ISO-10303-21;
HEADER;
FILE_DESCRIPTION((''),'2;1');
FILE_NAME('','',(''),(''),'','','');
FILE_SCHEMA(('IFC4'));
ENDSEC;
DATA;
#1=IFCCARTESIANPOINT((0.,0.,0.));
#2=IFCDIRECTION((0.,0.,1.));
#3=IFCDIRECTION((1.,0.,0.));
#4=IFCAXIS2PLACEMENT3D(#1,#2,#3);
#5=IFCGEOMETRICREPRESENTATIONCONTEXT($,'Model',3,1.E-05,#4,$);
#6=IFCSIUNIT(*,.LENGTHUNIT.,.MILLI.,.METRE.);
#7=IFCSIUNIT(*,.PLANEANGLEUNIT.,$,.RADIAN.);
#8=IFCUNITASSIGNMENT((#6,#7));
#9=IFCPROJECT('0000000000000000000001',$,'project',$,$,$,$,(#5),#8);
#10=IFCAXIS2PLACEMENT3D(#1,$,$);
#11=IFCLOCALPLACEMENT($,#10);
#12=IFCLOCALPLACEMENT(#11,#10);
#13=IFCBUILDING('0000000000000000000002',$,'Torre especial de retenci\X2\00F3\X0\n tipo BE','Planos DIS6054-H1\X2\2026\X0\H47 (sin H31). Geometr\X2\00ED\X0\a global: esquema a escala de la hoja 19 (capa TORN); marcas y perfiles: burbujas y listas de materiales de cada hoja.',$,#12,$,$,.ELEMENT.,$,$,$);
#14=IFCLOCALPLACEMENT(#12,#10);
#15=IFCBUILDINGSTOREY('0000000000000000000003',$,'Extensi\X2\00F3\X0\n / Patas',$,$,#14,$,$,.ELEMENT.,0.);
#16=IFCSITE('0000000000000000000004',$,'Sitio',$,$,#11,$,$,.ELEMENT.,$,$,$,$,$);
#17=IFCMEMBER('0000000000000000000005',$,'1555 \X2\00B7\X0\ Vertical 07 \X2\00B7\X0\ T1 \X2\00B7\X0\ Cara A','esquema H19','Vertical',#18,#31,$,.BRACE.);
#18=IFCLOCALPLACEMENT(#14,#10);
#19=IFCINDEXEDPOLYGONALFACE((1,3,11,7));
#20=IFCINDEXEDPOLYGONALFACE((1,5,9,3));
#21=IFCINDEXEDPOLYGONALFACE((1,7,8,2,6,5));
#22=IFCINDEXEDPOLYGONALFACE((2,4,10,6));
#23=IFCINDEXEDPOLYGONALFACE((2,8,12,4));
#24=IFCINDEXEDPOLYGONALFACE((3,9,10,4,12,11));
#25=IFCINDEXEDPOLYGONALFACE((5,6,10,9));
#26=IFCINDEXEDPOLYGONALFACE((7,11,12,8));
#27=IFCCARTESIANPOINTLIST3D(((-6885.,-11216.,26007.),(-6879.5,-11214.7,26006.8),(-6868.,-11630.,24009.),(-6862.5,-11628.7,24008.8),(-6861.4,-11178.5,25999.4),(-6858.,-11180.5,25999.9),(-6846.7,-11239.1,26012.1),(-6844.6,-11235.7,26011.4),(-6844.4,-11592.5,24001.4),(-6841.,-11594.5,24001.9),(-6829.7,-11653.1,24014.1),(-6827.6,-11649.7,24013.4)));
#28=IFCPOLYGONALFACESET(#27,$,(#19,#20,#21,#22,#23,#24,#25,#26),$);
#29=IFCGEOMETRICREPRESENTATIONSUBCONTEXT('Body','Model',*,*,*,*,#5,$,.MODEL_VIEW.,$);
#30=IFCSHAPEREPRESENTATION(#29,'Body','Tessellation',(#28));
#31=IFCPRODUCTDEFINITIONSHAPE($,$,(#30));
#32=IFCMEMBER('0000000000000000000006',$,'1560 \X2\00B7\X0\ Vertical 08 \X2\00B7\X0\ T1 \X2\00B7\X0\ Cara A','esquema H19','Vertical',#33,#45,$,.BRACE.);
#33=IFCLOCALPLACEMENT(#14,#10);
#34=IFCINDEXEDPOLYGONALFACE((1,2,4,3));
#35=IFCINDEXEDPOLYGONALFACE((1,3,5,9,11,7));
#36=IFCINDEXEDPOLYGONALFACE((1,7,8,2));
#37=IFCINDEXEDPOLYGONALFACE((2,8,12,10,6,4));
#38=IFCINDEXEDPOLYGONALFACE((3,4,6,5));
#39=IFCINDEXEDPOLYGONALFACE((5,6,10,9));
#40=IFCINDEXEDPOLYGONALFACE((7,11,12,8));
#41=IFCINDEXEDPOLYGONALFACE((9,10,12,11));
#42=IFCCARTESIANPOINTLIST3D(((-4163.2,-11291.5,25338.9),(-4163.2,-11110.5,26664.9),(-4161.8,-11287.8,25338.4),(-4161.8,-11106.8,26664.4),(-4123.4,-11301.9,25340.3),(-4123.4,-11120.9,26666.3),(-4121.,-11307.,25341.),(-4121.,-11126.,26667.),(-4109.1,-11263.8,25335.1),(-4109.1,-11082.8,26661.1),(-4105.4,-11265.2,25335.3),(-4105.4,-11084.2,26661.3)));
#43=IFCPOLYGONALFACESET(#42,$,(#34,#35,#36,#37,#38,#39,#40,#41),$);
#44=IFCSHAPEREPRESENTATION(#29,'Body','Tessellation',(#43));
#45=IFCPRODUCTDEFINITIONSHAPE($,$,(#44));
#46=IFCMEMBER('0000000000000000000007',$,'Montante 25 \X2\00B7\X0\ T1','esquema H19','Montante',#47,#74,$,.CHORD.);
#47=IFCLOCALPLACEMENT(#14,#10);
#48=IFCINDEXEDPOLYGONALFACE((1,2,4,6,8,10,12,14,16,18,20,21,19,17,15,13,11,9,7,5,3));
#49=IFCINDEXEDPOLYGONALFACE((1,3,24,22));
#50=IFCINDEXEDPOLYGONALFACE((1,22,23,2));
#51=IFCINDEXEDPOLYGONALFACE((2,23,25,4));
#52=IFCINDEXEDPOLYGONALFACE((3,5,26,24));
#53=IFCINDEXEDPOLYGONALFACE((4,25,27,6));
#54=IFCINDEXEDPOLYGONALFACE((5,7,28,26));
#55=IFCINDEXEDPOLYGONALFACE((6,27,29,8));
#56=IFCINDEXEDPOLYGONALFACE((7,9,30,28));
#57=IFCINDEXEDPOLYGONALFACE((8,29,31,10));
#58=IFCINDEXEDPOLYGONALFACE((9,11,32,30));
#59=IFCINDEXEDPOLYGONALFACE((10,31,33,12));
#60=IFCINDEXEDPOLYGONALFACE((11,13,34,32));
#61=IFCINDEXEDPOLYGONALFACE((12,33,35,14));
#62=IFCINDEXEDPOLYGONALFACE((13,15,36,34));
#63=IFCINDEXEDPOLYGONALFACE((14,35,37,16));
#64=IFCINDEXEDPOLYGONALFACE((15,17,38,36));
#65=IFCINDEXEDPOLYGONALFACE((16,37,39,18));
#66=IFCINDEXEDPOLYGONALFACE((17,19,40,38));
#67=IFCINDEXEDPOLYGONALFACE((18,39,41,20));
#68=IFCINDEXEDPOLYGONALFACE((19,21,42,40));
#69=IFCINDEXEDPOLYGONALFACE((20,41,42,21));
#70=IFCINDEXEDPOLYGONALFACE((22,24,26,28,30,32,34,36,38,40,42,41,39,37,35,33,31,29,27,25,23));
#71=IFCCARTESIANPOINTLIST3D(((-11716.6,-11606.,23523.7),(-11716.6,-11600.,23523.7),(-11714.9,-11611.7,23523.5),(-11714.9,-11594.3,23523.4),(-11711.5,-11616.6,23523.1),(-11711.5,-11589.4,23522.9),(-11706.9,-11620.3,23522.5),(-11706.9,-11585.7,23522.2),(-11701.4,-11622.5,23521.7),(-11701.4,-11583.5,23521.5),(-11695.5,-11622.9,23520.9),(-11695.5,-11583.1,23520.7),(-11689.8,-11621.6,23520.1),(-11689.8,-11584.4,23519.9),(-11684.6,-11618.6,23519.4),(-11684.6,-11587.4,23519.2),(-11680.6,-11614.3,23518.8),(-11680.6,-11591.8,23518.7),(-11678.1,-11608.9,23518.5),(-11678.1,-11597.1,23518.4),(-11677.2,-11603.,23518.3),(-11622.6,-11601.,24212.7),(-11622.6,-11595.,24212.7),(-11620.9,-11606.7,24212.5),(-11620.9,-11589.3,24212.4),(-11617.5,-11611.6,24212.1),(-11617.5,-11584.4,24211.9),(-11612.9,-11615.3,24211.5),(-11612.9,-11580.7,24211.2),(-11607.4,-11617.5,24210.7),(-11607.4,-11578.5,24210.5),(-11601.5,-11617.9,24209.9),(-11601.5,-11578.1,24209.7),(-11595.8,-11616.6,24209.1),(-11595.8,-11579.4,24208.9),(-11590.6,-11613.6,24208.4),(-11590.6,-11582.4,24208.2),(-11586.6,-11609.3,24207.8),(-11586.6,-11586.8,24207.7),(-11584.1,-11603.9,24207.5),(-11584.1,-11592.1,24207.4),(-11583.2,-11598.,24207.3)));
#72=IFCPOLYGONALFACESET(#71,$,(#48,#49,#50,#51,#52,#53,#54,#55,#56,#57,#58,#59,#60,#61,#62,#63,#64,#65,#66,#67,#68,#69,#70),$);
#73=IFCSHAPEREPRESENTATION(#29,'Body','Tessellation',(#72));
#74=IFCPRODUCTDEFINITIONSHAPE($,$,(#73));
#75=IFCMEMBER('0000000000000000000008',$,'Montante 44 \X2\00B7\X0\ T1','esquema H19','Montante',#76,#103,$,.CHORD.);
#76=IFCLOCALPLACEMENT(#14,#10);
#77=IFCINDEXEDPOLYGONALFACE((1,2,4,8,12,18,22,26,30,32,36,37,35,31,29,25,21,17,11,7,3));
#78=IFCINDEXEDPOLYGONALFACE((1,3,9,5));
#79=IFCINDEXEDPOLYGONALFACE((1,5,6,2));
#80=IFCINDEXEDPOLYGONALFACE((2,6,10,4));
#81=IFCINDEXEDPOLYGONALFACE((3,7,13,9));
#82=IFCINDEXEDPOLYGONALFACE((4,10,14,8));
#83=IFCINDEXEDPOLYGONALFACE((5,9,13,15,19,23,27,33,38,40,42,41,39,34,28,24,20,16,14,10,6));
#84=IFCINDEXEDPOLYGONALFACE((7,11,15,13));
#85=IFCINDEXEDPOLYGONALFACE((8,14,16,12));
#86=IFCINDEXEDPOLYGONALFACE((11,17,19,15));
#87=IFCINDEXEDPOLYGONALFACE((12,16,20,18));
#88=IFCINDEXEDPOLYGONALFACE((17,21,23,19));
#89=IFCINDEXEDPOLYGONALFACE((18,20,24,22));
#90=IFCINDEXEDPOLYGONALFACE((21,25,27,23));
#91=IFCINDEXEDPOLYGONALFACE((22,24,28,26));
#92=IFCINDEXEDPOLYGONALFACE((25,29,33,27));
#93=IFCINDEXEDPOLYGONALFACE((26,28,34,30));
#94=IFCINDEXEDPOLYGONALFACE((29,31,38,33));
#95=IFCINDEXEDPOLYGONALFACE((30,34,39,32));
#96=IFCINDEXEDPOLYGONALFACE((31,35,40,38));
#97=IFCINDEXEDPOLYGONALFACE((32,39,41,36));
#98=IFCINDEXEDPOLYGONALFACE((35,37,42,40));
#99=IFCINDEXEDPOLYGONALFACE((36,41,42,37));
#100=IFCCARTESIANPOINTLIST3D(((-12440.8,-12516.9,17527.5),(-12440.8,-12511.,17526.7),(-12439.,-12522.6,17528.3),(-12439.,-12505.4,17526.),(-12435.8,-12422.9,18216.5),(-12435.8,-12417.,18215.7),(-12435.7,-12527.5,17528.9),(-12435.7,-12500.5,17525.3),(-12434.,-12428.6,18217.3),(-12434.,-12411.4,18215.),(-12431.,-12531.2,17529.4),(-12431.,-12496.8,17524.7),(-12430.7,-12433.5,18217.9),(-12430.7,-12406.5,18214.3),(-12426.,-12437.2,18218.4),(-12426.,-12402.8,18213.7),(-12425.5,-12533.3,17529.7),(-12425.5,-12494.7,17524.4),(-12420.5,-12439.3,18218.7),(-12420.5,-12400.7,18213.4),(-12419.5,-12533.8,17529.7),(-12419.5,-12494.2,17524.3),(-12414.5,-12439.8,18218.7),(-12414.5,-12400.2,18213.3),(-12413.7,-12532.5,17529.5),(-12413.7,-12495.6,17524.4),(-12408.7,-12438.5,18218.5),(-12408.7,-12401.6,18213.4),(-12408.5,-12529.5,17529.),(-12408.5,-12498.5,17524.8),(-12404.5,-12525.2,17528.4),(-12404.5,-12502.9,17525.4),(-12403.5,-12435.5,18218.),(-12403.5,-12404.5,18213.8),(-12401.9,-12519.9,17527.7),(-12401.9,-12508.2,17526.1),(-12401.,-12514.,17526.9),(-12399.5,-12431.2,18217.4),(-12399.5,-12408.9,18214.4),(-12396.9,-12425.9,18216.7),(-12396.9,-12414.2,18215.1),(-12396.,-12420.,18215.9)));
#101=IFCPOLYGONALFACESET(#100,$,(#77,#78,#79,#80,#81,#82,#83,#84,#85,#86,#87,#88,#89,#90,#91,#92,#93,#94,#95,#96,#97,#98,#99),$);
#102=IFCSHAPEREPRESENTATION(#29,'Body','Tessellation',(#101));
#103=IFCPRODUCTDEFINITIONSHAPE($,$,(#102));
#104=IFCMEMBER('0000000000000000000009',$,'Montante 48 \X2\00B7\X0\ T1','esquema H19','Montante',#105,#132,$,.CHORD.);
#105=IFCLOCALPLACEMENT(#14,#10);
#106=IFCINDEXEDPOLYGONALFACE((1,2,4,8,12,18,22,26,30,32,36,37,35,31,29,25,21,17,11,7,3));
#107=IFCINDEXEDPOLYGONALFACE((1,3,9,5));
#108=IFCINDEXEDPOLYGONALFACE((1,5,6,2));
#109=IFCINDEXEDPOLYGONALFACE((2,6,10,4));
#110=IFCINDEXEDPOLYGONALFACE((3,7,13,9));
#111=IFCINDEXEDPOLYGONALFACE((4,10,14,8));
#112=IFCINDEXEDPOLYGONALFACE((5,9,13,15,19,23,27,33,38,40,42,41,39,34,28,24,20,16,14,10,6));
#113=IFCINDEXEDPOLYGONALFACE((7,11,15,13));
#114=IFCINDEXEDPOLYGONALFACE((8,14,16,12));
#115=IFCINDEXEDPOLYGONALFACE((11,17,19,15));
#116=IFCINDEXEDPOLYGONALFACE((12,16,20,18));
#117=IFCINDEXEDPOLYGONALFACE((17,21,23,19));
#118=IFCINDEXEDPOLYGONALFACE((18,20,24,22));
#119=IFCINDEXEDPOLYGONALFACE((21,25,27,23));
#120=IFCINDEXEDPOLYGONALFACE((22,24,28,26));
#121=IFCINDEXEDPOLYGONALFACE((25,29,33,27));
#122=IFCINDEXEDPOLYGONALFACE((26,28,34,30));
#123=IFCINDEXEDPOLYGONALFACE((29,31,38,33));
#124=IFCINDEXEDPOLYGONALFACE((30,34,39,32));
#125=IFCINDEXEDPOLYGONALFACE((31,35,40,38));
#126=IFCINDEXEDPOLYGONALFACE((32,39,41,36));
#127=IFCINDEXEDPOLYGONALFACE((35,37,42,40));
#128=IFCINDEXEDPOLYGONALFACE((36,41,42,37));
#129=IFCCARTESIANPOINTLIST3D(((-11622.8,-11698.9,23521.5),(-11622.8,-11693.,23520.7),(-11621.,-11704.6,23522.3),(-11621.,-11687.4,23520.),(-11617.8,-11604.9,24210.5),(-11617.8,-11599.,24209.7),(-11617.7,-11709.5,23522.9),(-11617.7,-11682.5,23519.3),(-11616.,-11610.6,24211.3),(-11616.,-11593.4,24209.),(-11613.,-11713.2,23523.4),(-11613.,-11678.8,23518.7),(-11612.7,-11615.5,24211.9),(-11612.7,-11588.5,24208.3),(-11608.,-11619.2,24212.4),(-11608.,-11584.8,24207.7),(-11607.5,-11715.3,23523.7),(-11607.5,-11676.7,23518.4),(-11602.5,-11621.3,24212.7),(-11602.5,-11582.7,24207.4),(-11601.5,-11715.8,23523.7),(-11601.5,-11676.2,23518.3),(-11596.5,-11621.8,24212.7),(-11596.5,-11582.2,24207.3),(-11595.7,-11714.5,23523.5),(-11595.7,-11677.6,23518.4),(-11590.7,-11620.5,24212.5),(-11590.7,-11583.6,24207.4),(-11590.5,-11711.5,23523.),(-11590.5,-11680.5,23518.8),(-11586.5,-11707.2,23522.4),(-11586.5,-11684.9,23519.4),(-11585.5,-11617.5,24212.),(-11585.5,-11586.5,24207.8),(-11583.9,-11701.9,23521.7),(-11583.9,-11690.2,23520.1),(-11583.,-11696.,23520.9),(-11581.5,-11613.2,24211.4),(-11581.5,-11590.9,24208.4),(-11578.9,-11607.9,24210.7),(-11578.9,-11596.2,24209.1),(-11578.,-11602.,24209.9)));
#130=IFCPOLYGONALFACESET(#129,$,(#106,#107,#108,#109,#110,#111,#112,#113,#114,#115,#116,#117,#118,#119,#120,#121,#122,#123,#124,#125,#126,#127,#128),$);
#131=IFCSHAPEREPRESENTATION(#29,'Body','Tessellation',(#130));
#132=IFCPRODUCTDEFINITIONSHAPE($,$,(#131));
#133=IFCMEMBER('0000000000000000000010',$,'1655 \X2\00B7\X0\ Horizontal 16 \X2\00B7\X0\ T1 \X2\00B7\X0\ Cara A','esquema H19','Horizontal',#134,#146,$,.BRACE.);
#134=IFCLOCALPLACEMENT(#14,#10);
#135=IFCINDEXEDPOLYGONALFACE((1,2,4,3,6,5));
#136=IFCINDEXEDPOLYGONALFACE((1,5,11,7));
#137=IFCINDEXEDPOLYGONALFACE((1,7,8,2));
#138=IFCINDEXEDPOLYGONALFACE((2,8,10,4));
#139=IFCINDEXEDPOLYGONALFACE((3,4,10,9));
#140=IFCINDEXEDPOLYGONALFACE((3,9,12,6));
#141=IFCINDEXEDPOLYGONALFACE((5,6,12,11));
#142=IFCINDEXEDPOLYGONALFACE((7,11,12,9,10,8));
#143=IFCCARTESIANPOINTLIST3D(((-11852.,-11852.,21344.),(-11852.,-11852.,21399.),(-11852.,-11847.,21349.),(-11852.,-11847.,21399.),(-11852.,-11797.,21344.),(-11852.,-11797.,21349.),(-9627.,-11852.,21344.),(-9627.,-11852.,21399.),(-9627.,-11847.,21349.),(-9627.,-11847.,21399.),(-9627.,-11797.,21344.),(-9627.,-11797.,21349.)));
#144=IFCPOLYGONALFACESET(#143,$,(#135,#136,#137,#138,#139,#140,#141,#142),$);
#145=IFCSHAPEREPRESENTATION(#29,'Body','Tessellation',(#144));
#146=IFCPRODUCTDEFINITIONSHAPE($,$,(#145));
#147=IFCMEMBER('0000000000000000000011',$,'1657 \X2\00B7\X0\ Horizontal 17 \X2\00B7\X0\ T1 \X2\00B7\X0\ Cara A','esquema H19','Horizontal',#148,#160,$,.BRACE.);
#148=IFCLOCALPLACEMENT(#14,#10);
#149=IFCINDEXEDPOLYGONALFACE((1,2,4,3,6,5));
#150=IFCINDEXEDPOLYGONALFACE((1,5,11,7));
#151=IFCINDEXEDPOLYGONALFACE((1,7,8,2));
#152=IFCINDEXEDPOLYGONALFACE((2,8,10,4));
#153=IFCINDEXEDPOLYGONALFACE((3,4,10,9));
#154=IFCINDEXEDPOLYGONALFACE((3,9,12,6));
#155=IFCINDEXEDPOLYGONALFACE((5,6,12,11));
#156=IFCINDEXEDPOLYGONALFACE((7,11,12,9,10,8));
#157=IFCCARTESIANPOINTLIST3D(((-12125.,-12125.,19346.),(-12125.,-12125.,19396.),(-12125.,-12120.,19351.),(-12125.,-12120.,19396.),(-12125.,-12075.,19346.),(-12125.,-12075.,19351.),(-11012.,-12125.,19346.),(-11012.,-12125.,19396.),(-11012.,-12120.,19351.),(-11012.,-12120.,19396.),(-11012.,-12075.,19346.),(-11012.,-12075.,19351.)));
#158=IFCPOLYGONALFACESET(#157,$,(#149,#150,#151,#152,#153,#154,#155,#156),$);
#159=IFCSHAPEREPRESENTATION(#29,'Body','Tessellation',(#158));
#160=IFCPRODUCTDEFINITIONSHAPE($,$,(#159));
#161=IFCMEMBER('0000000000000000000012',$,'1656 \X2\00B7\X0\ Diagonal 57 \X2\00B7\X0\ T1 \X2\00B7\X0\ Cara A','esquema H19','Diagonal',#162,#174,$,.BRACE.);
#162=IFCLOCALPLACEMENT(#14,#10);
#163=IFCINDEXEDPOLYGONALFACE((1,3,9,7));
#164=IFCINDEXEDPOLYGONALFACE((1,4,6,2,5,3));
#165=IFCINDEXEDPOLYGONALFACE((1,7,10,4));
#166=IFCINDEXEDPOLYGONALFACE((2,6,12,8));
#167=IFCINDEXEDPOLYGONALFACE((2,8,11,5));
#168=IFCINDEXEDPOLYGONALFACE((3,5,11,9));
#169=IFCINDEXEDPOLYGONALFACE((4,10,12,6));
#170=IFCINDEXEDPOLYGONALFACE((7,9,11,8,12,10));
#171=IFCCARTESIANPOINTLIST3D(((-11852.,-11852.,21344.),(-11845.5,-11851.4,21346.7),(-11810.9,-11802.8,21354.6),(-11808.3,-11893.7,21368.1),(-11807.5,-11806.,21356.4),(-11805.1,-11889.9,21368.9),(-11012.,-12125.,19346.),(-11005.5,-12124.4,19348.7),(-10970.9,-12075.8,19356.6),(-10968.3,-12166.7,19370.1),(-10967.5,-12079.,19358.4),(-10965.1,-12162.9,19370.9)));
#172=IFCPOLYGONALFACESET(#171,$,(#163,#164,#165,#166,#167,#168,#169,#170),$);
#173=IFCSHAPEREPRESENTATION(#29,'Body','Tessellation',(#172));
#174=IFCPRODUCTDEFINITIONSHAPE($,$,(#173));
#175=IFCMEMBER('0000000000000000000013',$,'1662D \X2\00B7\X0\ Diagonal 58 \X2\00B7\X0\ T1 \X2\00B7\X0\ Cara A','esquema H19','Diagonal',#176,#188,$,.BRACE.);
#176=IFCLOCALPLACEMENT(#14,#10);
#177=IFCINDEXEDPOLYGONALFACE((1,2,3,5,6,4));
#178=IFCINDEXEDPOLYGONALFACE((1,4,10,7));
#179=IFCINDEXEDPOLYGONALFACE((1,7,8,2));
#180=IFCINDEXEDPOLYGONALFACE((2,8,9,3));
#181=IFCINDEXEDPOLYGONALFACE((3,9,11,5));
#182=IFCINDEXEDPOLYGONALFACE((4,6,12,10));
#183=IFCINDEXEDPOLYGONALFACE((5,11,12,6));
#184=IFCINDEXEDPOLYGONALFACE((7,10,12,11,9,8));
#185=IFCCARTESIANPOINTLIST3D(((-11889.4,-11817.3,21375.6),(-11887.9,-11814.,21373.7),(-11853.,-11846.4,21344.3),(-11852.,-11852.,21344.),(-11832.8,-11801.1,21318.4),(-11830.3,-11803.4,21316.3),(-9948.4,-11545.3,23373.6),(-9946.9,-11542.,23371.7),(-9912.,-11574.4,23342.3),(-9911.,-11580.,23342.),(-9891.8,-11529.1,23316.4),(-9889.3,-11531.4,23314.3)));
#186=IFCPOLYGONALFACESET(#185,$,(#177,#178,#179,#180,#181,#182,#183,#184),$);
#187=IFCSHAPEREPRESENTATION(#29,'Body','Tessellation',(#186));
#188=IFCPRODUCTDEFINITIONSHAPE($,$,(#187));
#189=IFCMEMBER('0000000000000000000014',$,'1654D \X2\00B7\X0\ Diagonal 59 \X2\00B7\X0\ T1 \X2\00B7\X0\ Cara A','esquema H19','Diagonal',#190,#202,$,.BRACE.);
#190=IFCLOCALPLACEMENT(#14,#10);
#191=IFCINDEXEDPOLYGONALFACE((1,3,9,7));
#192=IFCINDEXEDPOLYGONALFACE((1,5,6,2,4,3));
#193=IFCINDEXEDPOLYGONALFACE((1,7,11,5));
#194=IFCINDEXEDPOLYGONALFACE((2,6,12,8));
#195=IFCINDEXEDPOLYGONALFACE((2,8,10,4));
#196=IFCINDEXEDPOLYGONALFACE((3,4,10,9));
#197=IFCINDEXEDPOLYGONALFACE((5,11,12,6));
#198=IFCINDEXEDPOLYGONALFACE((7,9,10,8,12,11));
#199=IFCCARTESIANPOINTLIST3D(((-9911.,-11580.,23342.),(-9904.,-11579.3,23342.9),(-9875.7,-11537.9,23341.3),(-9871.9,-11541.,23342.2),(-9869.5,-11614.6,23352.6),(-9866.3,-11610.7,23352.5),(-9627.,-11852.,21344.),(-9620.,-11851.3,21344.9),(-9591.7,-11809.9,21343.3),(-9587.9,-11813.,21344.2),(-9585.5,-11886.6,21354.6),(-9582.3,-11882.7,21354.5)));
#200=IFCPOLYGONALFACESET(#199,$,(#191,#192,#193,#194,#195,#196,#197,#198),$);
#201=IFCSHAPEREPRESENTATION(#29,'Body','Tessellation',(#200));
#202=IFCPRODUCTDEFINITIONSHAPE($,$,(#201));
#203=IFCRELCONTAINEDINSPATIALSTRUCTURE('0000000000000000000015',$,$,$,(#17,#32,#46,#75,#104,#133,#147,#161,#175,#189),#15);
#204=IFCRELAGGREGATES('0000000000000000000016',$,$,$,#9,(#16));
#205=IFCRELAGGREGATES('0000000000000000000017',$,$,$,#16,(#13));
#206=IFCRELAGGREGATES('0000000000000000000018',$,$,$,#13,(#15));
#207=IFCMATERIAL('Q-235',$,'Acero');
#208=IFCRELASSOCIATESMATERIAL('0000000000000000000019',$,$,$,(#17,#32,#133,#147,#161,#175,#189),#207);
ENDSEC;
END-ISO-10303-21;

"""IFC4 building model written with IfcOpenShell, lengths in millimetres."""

from ifc_helpers import new_model, si_unit, frame, frame_2d, origin, origin_with_axes, place, context, subcontext, project, spatial, circle, l_section, extrude, material, element, save


model = new_model("IFC4")

# Units and contexts
model_context = context("Model", 3, precision=1e-05, world=origin_with_axes())
body_context = subcontext(model_context, "Body", "Model", "MODEL_VIEW")
ifc_project = project(units=[si_unit("LENGTHUNIT", "METRE", prefix="MILLI"), si_unit("PLANEANGLEUNIT", "RADIAN")], contexts=[model_context])

# Site, building, storey
site_placement = place(None, origin())
site = spatial("IfcSite", under=ifc_project, at=site_placement, Name="Sitio", CompositionType="ELEMENT")
building_placement = place(site_placement, origin())
building = spatial("IfcBuilding", under=site, at=building_placement, Name="Torre especial de retención tipo BE", Description="Planos DIS6054-H1…H47 (sin H31). Geometría global: esquema a escala de la hoja 19 (capa TORN); marcas y perfiles: burbujas y listas de materiales de cada hoja.", CompositionType="ELEMENT")
storey_placement = place(building_placement, origin())
storey = spatial("IfcBuildingStorey", under=building, at=storey_placement, Name="Extensión / Patas", CompositionType="ELEMENT", Elevation=0.0)

# Members
ifc_material_1 = material(Name="Q-235", Category="Acero")
member_1_placement = place(storey_placement, frame((-6885.0, -11216.0, 26007.0), z_axis=(0.008331, -0.20289, -0.979166), x_axis=(0.524755, 0.834423, -0.168434)))
element("IfcMember", 1, at=member_1_placement, inside=storey, material=ifc_material_1, Name="1555 · Vertical 07 · T1 · Cara A", Description="esquema H19", ObjectType="Vertical", PredefinedType="BRACE", context=body_context, shape_type="SweptSolid", body=[
    extrude(l_section(Depth=45.0, Width=45.0, Thickness=4.0, at=frame_2d((22.5, 22.5))), None, (0.0, 0.0, 1.0), 2040.5),
])
member_2_placement = place(storey_placement, frame((-4121.0, -11307.0, 25341.0), z_axis=(0.0, 0.135247, 0.990812), x_axis=(0.347679, 0.928999, -0.126809)))
element("IfcMember", 2, at=member_2_placement, inside=storey, material=ifc_material_1, Name="1560 · Vertical 08 · T1 · Cara A", Description="esquema H19", ObjectType="Vertical", PredefinedType="BRACE", context=body_context, shape_type="SweptSolid", body=[
    extrude(l_section(Depth=45.0, Width=45.0, Thickness=4.0, at=frame_2d((22.5, 22.5))), None, (0.0, 0.0, 1.0), 1338.3),
])
for number, where, z_axis, x_axis, name in (
    (3, (-11697.0, -11603.0, 23521.0), (0.135174, 0.00719, 0.990796), (0.990822, -0.000981, -0.13517), "Montante 25 · T1"),
    (4, (-12421.0, -12514.0, 17527.0), (0.00719, 0.135174, 0.990796), (0.999974, -0.000972, -0.007124), "Montante 44 · T1"),
    (5, (-11603.0, -11696.0, 23521.0), (0.00719, 0.135174, 0.990796), (0.999974, -0.000972, -0.007124), "Montante 48 · T1"),
):
    element("IfcMember", number, at=place(storey_placement, frame(where, z_axis=z_axis, x_axis=x_axis)), inside=storey, Name=name, Description="esquema H19", ObjectType="Montante", PredefinedType="CHORD", context=body_context, shape_type="SweptSolid", body=[
        extrude(circle(Radius=20.0), None, (0.0, 0.0, 1.0), 695.4),
    ])
member_3_placement = place(storey_placement, frame((-11852.0, -11852.0, 21344.0), z_axis=(1.0, 0.0, 0.0), x_axis=(0.0, 1.0, 0.0)))
element("IfcMember", 6, at=member_3_placement, inside=storey, material=ifc_material_1, Name="1655 · Horizontal 16 · T1 · Cara A", Description="esquema H19", ObjectType="Horizontal", PredefinedType="BRACE", context=body_context, shape_type="SweptSolid", body=[
    extrude(l_section(Depth=55.0, Width=55.0, Thickness=5.0, at=frame_2d((27.5, 27.5))), None, (0.0, 0.0, 1.0), 2225.0),
])
member_4_placement = place(storey_placement, frame((-12125.0, -12125.0, 19346.0), z_axis=(1.0, 0.0, 0.0), x_axis=(0.0, 1.0, 0.0)))
element("IfcMember", 7, at=member_4_placement, inside=storey, material=ifc_material_1, Name="1657 · Horizontal 17 · T1 · Cara A", Description="esquema H19", ObjectType="Horizontal", PredefinedType="BRACE", context=body_context, shape_type="SweptSolid", body=[
    extrude(l_section(Depth=50.0, Width=50.0, Thickness=5.0, at=frame_2d((25.0, 25.0))), None, (0.0, 0.0, 1.0), 1113.0),
])
member_5_placement = place(storey_placement, frame((-11852.0, -11852.0, 21344.0), z_axis=(0.384524, -0.12497, -0.914617), x_axis=(0.632602, 0.757239, 0.162492)))
element("IfcMember", 8, at=member_5_placement, inside=storey, material=ifc_material_1, Name="1656 · Diagonal 57 · T1 · Cara A", Description="esquema H19", ObjectType="Diagonal", PredefinedType="BRACE", context=body_context, shape_type="SweptSolid", body=[
    extrude(l_section(Depth=65.0, Width=65.0, Thickness=5.0, at=frame_2d((32.5, 32.5))), None, (0.0, 0.0, 1.0), 2184.5),
])
member_6_placement = place(storey_placement, frame((-11852.0, -11852.0, 21344.0), z_axis=(0.693503, 0.097183, 0.713869), x_axis=(0.361883, 0.809802, -0.461803)))
element("IfcMember", 9, at=member_6_placement, inside=storey, material=ifc_material_1, Name="1662D · Diagonal 58 · T1 · Cara A", Description="esquema H19", ObjectType="Diagonal", PredefinedType="BRACE", context=body_context, shape_type="SweptSolid", body=[
    extrude(l_section(Depth=60.0, Width=60.0, Thickness=4.0, at=frame_2d((30.0, 30.0))), None, (0.0, 0.0, 1.0), 2798.8),
])
member_7_placement = place(storey_placement, frame((-9911.0, -11580.0, 23342.0), z_axis=(0.139467, -0.133574, -0.981176), x_axis=(0.642312, 0.766333, -0.013026)))
element("IfcMember", 10, at=member_7_placement, inside=storey, material=ifc_material_1, Name="1654D · Diagonal 59 · T1 · Cara A", Description="esquema H19", ObjectType="Diagonal", PredefinedType="BRACE", context=body_context, shape_type="SweptSolid", body=[
    extrude(l_section(Depth=55.0, Width=55.0, Thickness=5.0, at=frame_2d((27.5, 27.5))), None, (0.0, 0.0, 1.0), 2036.3),
])

save(model, "model.ifc")
